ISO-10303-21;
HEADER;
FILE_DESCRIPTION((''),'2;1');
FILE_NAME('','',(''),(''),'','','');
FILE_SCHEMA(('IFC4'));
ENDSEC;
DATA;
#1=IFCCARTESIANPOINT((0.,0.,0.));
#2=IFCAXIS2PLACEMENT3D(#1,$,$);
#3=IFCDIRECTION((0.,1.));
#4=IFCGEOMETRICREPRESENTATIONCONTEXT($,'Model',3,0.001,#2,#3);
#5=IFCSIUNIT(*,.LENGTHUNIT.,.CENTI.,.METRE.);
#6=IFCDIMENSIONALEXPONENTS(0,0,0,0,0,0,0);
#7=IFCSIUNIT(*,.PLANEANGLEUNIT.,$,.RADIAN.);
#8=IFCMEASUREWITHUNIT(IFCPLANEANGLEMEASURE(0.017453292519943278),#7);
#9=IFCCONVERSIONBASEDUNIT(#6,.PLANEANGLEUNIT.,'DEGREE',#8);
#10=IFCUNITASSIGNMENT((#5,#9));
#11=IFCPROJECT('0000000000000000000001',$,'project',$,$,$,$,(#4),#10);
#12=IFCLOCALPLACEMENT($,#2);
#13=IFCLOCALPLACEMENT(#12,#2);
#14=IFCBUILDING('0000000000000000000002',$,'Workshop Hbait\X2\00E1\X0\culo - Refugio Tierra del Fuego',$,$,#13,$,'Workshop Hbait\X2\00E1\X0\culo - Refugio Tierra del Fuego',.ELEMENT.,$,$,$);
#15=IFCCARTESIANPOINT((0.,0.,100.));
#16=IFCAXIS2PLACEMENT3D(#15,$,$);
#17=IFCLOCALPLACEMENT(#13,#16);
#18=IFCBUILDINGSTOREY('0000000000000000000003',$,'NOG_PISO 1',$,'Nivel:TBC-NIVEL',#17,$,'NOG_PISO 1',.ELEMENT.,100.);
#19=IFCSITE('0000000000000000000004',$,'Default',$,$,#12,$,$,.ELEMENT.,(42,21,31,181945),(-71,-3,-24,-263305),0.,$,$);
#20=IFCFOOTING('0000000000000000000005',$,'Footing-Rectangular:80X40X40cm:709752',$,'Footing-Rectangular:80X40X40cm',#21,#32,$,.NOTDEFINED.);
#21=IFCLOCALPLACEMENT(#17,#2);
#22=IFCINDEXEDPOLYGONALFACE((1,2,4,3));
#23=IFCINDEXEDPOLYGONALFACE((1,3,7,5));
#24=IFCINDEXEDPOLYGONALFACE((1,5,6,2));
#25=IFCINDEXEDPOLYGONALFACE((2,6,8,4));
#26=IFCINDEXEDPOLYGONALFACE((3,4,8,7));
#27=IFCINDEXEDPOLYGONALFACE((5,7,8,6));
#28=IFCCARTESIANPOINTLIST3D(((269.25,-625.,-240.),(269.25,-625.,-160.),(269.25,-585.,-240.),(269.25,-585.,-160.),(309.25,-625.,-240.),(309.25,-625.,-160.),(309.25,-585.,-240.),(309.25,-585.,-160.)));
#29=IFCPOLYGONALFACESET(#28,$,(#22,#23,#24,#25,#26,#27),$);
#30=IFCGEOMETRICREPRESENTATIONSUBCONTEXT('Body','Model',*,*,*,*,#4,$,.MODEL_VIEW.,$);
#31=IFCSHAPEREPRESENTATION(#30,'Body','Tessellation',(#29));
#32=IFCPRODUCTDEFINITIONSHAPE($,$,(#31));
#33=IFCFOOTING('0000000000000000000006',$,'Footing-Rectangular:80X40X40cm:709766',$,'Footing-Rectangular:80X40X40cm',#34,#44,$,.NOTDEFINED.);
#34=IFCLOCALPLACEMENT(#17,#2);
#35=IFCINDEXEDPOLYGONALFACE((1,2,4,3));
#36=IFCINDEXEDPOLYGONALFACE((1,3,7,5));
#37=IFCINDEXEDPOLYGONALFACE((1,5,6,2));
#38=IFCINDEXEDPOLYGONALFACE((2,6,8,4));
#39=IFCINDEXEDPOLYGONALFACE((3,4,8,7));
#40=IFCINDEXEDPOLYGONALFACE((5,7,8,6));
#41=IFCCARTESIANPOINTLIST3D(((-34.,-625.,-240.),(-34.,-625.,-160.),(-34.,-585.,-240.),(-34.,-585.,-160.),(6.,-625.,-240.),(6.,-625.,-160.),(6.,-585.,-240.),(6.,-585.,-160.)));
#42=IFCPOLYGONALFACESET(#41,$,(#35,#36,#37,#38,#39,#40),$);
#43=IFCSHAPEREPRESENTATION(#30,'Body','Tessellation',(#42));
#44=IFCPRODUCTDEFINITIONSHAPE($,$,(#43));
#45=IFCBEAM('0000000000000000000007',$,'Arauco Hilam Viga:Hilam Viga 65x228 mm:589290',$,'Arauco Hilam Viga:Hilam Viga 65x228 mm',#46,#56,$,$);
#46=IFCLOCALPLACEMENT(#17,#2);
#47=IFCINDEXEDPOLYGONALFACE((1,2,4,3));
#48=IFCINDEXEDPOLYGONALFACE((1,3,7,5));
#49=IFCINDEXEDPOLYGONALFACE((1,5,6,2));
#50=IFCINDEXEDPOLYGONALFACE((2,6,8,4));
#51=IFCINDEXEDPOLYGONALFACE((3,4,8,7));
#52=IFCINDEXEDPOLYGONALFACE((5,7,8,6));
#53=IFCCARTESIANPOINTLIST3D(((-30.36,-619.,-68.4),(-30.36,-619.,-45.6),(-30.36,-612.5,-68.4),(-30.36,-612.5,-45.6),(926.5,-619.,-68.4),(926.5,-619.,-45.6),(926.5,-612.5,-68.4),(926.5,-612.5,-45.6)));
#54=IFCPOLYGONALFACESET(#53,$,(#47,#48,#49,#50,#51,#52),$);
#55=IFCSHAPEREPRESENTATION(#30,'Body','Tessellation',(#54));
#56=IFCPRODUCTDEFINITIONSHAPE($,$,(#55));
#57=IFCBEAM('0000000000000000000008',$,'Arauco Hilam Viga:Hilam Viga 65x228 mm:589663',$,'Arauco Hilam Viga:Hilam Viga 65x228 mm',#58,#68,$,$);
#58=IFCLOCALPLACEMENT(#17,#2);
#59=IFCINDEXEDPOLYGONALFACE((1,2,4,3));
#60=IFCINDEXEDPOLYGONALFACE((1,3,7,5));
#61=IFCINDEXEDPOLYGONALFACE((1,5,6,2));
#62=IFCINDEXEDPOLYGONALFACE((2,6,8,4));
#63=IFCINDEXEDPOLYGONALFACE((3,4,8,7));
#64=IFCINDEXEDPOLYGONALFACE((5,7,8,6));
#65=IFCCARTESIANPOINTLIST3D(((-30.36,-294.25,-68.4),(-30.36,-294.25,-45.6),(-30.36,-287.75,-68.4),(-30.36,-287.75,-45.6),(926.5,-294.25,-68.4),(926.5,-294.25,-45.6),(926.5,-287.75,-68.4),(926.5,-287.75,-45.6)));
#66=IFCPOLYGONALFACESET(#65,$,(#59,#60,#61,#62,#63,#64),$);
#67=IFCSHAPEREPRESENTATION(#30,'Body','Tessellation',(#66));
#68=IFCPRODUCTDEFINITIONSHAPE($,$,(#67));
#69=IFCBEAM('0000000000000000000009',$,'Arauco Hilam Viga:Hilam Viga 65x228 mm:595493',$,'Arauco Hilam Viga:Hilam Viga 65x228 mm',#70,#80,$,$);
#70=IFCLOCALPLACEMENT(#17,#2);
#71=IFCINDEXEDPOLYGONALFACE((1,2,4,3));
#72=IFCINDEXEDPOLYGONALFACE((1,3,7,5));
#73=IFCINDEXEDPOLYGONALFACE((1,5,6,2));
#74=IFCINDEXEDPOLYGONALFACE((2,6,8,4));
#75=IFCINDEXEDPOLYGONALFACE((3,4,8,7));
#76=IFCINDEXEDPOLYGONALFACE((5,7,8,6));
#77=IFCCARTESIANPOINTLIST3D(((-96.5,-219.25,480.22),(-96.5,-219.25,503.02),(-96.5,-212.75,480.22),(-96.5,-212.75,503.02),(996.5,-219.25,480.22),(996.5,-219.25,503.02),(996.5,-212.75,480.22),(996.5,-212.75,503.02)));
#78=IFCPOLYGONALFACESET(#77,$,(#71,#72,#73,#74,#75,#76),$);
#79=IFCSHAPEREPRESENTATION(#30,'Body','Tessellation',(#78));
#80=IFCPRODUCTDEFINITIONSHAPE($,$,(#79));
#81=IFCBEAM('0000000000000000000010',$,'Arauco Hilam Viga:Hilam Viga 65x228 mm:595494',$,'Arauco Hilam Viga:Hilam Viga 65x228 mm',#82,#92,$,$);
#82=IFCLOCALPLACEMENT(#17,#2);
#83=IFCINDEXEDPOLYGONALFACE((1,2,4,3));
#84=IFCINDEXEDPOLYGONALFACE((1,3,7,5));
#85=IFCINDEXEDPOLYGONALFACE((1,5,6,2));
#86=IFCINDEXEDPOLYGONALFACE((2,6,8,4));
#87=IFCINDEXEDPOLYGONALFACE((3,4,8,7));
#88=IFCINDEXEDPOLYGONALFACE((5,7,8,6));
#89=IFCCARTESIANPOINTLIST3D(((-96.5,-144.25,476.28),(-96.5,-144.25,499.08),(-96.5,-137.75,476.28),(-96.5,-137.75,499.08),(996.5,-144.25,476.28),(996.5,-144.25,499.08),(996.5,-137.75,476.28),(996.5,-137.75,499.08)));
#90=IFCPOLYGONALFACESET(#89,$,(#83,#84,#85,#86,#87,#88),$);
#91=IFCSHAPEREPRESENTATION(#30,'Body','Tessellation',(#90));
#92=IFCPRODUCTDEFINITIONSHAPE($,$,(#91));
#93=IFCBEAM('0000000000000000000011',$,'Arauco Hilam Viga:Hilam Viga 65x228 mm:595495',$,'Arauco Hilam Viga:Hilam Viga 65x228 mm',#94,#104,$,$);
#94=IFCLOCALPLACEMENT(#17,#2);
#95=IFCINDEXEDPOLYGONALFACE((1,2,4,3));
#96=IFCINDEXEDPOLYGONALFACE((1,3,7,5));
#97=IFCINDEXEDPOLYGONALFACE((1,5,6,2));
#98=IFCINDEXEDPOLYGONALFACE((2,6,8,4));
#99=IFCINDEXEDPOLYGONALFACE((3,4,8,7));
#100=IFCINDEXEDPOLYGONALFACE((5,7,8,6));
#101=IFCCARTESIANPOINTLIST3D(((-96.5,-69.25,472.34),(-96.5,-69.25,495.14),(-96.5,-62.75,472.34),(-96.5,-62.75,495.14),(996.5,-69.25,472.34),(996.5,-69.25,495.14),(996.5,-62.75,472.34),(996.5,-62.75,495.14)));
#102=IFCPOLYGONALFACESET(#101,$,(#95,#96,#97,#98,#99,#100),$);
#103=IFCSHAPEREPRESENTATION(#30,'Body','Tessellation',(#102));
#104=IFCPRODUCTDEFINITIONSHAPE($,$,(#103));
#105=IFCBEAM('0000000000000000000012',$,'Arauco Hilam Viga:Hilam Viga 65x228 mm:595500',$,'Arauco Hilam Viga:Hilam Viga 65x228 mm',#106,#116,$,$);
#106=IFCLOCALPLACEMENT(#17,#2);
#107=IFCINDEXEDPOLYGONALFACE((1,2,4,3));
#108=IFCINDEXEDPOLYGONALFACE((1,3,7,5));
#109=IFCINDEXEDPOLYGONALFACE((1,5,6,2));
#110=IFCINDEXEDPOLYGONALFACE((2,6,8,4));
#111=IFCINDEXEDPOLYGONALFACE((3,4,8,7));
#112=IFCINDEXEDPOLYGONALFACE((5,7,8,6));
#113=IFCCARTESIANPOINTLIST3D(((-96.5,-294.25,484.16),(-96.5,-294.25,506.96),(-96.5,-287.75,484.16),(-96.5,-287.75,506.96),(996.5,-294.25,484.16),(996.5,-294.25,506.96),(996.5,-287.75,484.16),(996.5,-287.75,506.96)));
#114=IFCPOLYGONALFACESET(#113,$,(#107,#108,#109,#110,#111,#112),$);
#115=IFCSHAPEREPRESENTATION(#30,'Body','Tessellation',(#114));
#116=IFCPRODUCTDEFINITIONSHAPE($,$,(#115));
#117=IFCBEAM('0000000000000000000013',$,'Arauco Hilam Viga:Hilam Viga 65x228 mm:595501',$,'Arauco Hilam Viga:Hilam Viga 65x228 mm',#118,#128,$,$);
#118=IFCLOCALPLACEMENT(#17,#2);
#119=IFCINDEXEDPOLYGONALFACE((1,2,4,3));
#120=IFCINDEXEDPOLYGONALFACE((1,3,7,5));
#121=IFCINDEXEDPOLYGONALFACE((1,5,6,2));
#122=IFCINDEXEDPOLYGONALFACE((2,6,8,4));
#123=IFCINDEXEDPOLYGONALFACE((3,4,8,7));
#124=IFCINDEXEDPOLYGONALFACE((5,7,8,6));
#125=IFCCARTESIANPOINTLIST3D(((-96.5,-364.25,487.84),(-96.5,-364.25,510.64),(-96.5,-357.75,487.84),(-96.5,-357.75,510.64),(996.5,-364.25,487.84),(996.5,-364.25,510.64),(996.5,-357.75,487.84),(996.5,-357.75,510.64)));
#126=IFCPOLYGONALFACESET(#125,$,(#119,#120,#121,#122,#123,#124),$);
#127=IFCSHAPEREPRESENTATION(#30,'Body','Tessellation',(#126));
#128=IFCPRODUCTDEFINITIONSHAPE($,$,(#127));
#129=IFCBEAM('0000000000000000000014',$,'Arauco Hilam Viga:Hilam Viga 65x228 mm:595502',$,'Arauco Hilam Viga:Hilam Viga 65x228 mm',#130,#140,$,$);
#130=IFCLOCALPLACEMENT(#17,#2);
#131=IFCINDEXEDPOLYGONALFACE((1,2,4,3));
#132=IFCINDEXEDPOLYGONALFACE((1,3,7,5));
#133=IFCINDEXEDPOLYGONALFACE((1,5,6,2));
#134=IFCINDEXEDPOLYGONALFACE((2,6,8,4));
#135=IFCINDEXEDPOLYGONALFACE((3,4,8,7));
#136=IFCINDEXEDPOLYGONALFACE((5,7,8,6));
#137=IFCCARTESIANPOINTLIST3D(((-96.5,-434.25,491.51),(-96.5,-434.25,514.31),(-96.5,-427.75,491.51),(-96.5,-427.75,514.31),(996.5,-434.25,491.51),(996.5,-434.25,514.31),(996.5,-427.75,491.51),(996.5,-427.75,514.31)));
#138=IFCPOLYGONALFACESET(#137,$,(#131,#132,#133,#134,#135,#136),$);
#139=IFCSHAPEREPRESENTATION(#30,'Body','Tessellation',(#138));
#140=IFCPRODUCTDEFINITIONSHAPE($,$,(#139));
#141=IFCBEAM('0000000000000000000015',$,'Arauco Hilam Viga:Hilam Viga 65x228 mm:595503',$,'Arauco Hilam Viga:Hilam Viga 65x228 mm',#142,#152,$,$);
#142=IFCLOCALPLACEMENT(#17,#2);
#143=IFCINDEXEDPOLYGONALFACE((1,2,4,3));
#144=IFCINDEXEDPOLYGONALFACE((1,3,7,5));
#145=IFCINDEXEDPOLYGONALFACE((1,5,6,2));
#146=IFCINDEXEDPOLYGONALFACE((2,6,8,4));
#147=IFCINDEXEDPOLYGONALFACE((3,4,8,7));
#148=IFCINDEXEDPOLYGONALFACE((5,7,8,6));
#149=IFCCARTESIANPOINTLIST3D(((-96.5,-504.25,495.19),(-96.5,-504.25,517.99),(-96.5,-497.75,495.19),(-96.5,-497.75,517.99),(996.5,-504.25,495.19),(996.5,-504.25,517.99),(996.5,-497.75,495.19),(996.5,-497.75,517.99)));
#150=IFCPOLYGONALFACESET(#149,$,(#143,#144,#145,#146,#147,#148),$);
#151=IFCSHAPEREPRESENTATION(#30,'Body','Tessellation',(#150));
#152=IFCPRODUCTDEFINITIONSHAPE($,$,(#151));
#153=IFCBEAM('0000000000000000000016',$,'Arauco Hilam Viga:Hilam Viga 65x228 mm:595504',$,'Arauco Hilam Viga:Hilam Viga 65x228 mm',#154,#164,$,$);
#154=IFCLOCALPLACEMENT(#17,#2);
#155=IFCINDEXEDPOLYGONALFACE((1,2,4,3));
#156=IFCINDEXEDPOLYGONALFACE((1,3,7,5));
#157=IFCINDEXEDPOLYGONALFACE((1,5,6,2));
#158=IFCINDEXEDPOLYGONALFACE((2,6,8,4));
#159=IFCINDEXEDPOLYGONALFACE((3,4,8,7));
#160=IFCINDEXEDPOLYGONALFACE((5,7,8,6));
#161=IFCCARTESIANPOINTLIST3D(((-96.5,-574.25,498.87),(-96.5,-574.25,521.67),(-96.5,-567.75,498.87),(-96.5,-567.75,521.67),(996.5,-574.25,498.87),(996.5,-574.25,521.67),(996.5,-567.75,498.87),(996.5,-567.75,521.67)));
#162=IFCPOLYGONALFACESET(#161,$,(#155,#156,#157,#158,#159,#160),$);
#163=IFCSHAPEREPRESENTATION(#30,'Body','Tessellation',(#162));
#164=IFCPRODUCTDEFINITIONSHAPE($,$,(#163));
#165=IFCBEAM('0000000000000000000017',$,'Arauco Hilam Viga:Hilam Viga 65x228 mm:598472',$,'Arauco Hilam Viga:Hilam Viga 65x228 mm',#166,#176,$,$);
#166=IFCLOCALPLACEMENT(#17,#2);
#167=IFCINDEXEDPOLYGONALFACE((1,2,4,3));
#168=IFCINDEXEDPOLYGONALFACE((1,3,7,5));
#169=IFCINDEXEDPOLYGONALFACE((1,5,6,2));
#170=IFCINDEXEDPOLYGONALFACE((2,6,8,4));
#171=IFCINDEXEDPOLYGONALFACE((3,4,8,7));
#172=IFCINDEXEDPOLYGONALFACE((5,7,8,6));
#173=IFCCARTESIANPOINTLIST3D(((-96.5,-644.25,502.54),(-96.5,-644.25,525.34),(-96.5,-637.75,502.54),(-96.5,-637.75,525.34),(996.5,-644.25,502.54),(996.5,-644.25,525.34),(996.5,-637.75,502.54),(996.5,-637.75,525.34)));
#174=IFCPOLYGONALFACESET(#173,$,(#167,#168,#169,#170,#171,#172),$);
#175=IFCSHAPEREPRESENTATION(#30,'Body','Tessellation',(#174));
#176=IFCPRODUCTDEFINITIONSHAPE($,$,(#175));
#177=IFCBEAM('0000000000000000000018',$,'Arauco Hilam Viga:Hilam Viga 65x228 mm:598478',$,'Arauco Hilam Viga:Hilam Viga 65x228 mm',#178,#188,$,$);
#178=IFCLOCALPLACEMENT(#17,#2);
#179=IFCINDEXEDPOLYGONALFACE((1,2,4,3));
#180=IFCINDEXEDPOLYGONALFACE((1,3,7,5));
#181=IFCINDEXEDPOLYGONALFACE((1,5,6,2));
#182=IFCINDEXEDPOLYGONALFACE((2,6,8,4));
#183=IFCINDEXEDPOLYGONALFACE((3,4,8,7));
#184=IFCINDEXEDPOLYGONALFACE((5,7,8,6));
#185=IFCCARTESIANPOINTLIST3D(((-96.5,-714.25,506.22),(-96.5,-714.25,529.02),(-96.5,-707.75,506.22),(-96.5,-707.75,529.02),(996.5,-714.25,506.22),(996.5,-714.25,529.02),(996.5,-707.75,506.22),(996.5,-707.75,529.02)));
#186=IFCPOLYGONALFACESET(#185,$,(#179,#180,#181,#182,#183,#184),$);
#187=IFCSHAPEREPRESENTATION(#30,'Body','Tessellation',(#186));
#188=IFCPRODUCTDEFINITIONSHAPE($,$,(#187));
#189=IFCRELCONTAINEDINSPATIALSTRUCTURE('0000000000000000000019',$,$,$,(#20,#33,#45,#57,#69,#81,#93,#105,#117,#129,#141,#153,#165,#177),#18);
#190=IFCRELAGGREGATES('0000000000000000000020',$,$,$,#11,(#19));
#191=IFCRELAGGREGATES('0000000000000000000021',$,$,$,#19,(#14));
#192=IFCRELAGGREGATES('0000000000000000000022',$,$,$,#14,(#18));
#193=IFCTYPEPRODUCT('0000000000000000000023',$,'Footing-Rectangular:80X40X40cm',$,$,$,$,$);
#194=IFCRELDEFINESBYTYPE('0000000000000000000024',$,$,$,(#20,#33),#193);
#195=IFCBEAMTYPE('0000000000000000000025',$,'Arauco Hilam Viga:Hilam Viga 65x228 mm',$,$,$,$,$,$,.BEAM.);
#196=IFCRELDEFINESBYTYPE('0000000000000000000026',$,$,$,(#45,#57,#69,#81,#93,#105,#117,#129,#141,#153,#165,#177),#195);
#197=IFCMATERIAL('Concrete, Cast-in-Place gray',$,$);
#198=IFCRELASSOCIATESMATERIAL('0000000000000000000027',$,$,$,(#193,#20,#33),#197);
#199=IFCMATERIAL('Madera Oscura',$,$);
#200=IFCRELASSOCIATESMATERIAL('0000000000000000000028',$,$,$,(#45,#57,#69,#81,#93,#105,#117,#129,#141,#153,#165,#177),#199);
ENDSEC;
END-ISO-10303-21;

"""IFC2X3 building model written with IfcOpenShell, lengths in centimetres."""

from ifc_helpers import new_model, entity, si_unit, converted_unit, direction, frame, frame_2d, origin, origin_2d_with_axis, place, context, subcontext, project, spatial, rectangle, extrude, source, transform, mapped, material, type_object, type_shapes, element, save


model = new_model("IFC2X3")

# Units and contexts
model_context = context("Model", 3, precision=0.001, world=origin(), true_north=direction((0.0, 1.0)))
body_context = subcontext(model_context, "Body", "Model", "MODEL_VIEW")
ifc_project = project(units=[si_unit("LENGTHUNIT", "METRE", prefix="CENTI"), converted_unit("PLANEANGLEUNIT", "DEGREE", entity("IfcPlaneAngleMeasure", 0.017453292519943278), si_unit("PLANEANGLEUNIT", "RADIAN"), dimensions=[0, 0, 0, 0, 0, 0, 0])], contexts=[model_context])

# Site, building, storey
site_placement = place(None, origin())
site = spatial("IfcSite", under=ifc_project, at=site_placement, Name="Default", CompositionType="ELEMENT", RefLatitude=(42, 21, 31, 181945), RefLongitude=(-71, -3, -24, -263305), RefElevation=0.0)
building_placement = place(site_placement, origin())
building = spatial("IfcBuilding", under=site, at=building_placement, Name="Workshop Hbaitáculo - Refugio Tierra del Fuego", LongName="Workshop Hbaitáculo - Refugio Tierra del Fuego", CompositionType="ELEMENT")
storey_placement = place(building_placement, frame((0.0, 0.0, 100.0)))
storey = spatial("IfcBuildingStorey", under=building, at=storey_placement, Name="NOG_PISO 1", ObjectType="Nivel:TBC-NIVEL", LongName="NOG_PISO 1", CompositionType="ELEMENT", Elevation=100.0)

# Footings
ifc_material_1 = material(Name="Concrete, Cast-in-Place gray")
type_product = type_object("IfcTypeProduct", Name="Footing-Rectangular:80X40X40cm", material=ifc_material_1)
shared_shape_1 = source(origin(), body_context, "Body", "SweptSolid", [
    extrude(rectangle(XDim=40.0, YDim=40.0, at=origin_2d_with_axis()), frame((0.0, 0.0, -80.0), z_axis=(0.0, 0.0, 1.0), x_axis=(-1.0, 0.0, 0.0)), (0.0, 0.0, 1.0), 80.0),
])
type_shapes(type_product, [shared_shape_1])
for number, where, name in (
    (1, (289.25, -605.0, -160.0), "Footing-Rectangular:80X40X40cm:709752"),
    (2, (-14.0, -605.0, -160.0), "Footing-Rectangular:80X40X40cm:709766"),
):
    element("IfcFooting", number, at=place(storey_placement, frame(where)), inside=storey, type_object=type_product, material=ifc_material_1, Name=name, ObjectType="Footing-Rectangular:80X40X40cm", PredefinedType="NOTDEFINED", context=body_context, shape_type="MappedRepresentation", body=[
        mapped(shared_shape_1, transform((0.0, 0.0, 0.0), scale=1.0)),
    ])

# Beams
ifc_material_2 = material(Name="Madera Oscura")
beam_type = type_object("IfcBeamType", Name="Arauco Hilam Viga:Hilam Viga 65x228 mm", PredefinedType="BEAM")
beam_1_placement = place(storey_placement, frame((-96.14, -615.75, -45.6)))
element("IfcBeam", 3, at=beam_1_placement, inside=storey, type_object=beam_type, material=ifc_material_2, Name="Arauco Hilam Viga:Hilam Viga 65x228 mm:589290", ObjectType="Arauco Hilam Viga:Hilam Viga 65x228 mm", context=body_context, shape_type="SweptSolid", body=[
    extrude(rectangle(XDim=22.8, YDim=6.5, at=origin_2d_with_axis()), frame((65.78, 0.0, -11.4), z_axis=(1.0, 0.0, 0.0), x_axis=(0.0, 0.0, -1.0)), (0.0, 0.0, 1.0), 956.86),
])
beam_2_placement = place(storey_placement, frame((-96.14, -291.0, -45.6)))
element("IfcBeam", 4, at=beam_2_placement, inside=storey, type_object=beam_type, material=ifc_material_2, Name="Arauco Hilam Viga:Hilam Viga 65x228 mm:589663", ObjectType="Arauco Hilam Viga:Hilam Viga 65x228 mm", context=body_context, shape_type="SweptSolid", body=[
    extrude(rectangle(XDim=22.8, YDim=6.5, at=frame_2d((0.0, 0.0), x_axis=(1.0, 0.0))), frame((65.78, 0.0, -11.4), z_axis=(1.0, 0.0, 0.0), x_axis=(0.0, 0.0, -1.0)), (0.0, 0.0, 1.0), 956.86),
])
beam_3_placement = place(storey_placement, frame((-127.75, -216.0, 503.02)))
element("IfcBeam", 5, at=beam_3_placement, inside=storey, type_object=beam_type, material=ifc_material_2, Name="Arauco Hilam Viga:Hilam Viga 65x228 mm:595493", ObjectType="Arauco Hilam Viga:Hilam Viga 65x228 mm", context=body_context, shape_type="SweptSolid", body=[
    extrude(rectangle(XDim=22.8, YDim=6.5, at=frame_2d((0.0, 0.0), x_axis=(1.0, 0.0))), frame((31.25, 0.0, -11.4), z_axis=(1.0, 0.0, 0.0), x_axis=(0.0, 0.0, -1.0)), (0.0, 0.0, 1.0), 1093.0),
])
beam_4_placement = place(storey_placement, frame((-127.75, -141.0, 499.08)))
element("IfcBeam", 6, at=beam_4_placement, inside=storey, type_object=beam_type, material=ifc_material_2, Name="Arauco Hilam Viga:Hilam Viga 65x228 mm:595494", ObjectType="Arauco Hilam Viga:Hilam Viga 65x228 mm", context=body_context, shape_type="SweptSolid", body=[
    extrude(rectangle(XDim=22.8, YDim=6.5, at=frame_2d((0.0, 0.0), x_axis=(1.0, 0.0))), frame((31.25, 0.0, -11.4), z_axis=(1.0, 0.0, 0.0), x_axis=(0.0, 0.0, -1.0)), (0.0, 0.0, 1.0), 1093.0),
])
beam_5_placement = place(storey_placement, frame((-127.75, -66.0, 495.14)))
element("IfcBeam", 7, at=beam_5_placement, inside=storey, type_object=beam_type, material=ifc_material_2, Name="Arauco Hilam Viga:Hilam Viga 65x228 mm:595495", ObjectType="Arauco Hilam Viga:Hilam Viga 65x228 mm", context=body_context, shape_type="SweptSolid", body=[
    extrude(rectangle(XDim=22.8, YDim=6.5, at=origin_2d_with_axis()), frame((31.25, 0.0, -11.4), z_axis=(1.0, 0.0, 0.0), x_axis=(0.0, 0.0, -1.0)), (0.0, 0.0, 1.0), 1093.0),
])
for number, where, name in (
    (8, (-127.75, -291.0, 506.96), "Arauco Hilam Viga:Hilam Viga 65x228 mm:595500"),
    (9, (-127.75, -361.0, 510.64), "Arauco Hilam Viga:Hilam Viga 65x228 mm:595501"),
):
    element("IfcBeam", number, at=place(storey_placement, frame(where)), inside=storey, type_object=beam_type, material=ifc_material_2, Name=name, ObjectType="Arauco Hilam Viga:Hilam Viga 65x228 mm", context=body_context, shape_type="SweptSolid", body=[
        extrude(rectangle(XDim=22.8, YDim=6.5, at=frame_2d((0.0, 0.0), x_axis=(1.0, 0.0))), frame((31.25, 0.0, -11.4), z_axis=(1.0, 0.0, 0.0), x_axis=(0.0, 0.0, -1.0)), (0.0, 0.0, 1.0), 1093.0),
    ])
beam_6_placement = place(storey_placement, frame((-127.75, -431.0, 514.31)))
element("IfcBeam", 10, at=beam_6_placement, inside=storey, type_object=beam_type, material=ifc_material_2, Name="Arauco Hilam Viga:Hilam Viga 65x228 mm:595502", ObjectType="Arauco Hilam Viga:Hilam Viga 65x228 mm", context=body_context, shape_type="SweptSolid", body=[
    extrude(rectangle(XDim=22.8, YDim=6.5, at=frame_2d((0.0, 0.0), x_axis=(1.0, 0.0))), frame((31.25, 0.0, -11.4), z_axis=(1.0, 0.0, 0.0), x_axis=(0.0, 0.0, -1.0)), (0.0, 0.0, 1.0), 1093.0),
])
beam_7_placement = place(storey_placement, frame((-127.75, -501.0, 517.99)))
element("IfcBeam", 11, at=beam_7_placement, inside=storey, type_object=beam_type, material=ifc_material_2, Name="Arauco Hilam Viga:Hilam Viga 65x228 mm:595503", ObjectType="Arauco Hilam Viga:Hilam Viga 65x228 mm", context=body_context, shape_type="SweptSolid", body=[
    extrude(rectangle(XDim=22.8, YDim=6.5, at=origin_2d_with_axis()), frame((31.25, 0.0, -11.4), z_axis=(1.0, 0.0, 0.0), x_axis=(0.0, 0.0, -1.0)), (0.0, 0.0, 1.0), 1093.0),
])
beam_8_placement = place(storey_placement, frame((-127.75, -571.0, 521.67)))
element("IfcBeam", 12, at=beam_8_placement, inside=storey, type_object=beam_type, material=ifc_material_2, Name="Arauco Hilam Viga:Hilam Viga 65x228 mm:595504", ObjectType="Arauco Hilam Viga:Hilam Viga 65x228 mm", context=body_context, shape_type="SweptSolid", body=[
    extrude(rectangle(XDim=22.8, YDim=6.5, at=origin_2d_with_axis()), frame((31.25, 0.0, -11.4), z_axis=(1.0, 0.0, 0.0), x_axis=(0.0, 0.0, -1.0)), (0.0, 0.0, 1.0), 1093.0),
])
beam_9_placement = place(storey_placement, frame((-127.75, -641.0, 525.34)))
element("IfcBeam", 13, at=beam_9_placement, inside=storey, type_object=beam_type, material=ifc_material_2, Name="Arauco Hilam Viga:Hilam Viga 65x228 mm:598472", ObjectType="Arauco Hilam Viga:Hilam Viga 65x228 mm", context=body_context, shape_type="SweptSolid", body=[
    extrude(rectangle(XDim=22.8, YDim=6.5, at=origin_2d_with_axis()), frame((31.25, 0.0, -11.4), z_axis=(1.0, 0.0, 0.0), x_axis=(0.0, 0.0, -1.0)), (0.0, 0.0, 1.0), 1093.0),
])
beam_10_placement = place(storey_placement, frame((-127.75, -711.0, 529.02)))
element("IfcBeam", 14, at=beam_10_placement, inside=storey, type_object=beam_type, material=ifc_material_2, Name="Arauco Hilam Viga:Hilam Viga 65x228 mm:598478", ObjectType="Arauco Hilam Viga:Hilam Viga 65x228 mm", context=body_context, shape_type="SweptSolid", body=[
    extrude(rectangle(XDim=22.8, YDim=6.5, at=origin_2d_with_axis()), frame((31.25, 0.0, -11.4), z_axis=(1.0, 0.0, 0.0), x_axis=(0.0, 0.0, -1.0)), (0.0, 0.0, 1.0), 1093.0),
])

save(model, "model.ifc")
